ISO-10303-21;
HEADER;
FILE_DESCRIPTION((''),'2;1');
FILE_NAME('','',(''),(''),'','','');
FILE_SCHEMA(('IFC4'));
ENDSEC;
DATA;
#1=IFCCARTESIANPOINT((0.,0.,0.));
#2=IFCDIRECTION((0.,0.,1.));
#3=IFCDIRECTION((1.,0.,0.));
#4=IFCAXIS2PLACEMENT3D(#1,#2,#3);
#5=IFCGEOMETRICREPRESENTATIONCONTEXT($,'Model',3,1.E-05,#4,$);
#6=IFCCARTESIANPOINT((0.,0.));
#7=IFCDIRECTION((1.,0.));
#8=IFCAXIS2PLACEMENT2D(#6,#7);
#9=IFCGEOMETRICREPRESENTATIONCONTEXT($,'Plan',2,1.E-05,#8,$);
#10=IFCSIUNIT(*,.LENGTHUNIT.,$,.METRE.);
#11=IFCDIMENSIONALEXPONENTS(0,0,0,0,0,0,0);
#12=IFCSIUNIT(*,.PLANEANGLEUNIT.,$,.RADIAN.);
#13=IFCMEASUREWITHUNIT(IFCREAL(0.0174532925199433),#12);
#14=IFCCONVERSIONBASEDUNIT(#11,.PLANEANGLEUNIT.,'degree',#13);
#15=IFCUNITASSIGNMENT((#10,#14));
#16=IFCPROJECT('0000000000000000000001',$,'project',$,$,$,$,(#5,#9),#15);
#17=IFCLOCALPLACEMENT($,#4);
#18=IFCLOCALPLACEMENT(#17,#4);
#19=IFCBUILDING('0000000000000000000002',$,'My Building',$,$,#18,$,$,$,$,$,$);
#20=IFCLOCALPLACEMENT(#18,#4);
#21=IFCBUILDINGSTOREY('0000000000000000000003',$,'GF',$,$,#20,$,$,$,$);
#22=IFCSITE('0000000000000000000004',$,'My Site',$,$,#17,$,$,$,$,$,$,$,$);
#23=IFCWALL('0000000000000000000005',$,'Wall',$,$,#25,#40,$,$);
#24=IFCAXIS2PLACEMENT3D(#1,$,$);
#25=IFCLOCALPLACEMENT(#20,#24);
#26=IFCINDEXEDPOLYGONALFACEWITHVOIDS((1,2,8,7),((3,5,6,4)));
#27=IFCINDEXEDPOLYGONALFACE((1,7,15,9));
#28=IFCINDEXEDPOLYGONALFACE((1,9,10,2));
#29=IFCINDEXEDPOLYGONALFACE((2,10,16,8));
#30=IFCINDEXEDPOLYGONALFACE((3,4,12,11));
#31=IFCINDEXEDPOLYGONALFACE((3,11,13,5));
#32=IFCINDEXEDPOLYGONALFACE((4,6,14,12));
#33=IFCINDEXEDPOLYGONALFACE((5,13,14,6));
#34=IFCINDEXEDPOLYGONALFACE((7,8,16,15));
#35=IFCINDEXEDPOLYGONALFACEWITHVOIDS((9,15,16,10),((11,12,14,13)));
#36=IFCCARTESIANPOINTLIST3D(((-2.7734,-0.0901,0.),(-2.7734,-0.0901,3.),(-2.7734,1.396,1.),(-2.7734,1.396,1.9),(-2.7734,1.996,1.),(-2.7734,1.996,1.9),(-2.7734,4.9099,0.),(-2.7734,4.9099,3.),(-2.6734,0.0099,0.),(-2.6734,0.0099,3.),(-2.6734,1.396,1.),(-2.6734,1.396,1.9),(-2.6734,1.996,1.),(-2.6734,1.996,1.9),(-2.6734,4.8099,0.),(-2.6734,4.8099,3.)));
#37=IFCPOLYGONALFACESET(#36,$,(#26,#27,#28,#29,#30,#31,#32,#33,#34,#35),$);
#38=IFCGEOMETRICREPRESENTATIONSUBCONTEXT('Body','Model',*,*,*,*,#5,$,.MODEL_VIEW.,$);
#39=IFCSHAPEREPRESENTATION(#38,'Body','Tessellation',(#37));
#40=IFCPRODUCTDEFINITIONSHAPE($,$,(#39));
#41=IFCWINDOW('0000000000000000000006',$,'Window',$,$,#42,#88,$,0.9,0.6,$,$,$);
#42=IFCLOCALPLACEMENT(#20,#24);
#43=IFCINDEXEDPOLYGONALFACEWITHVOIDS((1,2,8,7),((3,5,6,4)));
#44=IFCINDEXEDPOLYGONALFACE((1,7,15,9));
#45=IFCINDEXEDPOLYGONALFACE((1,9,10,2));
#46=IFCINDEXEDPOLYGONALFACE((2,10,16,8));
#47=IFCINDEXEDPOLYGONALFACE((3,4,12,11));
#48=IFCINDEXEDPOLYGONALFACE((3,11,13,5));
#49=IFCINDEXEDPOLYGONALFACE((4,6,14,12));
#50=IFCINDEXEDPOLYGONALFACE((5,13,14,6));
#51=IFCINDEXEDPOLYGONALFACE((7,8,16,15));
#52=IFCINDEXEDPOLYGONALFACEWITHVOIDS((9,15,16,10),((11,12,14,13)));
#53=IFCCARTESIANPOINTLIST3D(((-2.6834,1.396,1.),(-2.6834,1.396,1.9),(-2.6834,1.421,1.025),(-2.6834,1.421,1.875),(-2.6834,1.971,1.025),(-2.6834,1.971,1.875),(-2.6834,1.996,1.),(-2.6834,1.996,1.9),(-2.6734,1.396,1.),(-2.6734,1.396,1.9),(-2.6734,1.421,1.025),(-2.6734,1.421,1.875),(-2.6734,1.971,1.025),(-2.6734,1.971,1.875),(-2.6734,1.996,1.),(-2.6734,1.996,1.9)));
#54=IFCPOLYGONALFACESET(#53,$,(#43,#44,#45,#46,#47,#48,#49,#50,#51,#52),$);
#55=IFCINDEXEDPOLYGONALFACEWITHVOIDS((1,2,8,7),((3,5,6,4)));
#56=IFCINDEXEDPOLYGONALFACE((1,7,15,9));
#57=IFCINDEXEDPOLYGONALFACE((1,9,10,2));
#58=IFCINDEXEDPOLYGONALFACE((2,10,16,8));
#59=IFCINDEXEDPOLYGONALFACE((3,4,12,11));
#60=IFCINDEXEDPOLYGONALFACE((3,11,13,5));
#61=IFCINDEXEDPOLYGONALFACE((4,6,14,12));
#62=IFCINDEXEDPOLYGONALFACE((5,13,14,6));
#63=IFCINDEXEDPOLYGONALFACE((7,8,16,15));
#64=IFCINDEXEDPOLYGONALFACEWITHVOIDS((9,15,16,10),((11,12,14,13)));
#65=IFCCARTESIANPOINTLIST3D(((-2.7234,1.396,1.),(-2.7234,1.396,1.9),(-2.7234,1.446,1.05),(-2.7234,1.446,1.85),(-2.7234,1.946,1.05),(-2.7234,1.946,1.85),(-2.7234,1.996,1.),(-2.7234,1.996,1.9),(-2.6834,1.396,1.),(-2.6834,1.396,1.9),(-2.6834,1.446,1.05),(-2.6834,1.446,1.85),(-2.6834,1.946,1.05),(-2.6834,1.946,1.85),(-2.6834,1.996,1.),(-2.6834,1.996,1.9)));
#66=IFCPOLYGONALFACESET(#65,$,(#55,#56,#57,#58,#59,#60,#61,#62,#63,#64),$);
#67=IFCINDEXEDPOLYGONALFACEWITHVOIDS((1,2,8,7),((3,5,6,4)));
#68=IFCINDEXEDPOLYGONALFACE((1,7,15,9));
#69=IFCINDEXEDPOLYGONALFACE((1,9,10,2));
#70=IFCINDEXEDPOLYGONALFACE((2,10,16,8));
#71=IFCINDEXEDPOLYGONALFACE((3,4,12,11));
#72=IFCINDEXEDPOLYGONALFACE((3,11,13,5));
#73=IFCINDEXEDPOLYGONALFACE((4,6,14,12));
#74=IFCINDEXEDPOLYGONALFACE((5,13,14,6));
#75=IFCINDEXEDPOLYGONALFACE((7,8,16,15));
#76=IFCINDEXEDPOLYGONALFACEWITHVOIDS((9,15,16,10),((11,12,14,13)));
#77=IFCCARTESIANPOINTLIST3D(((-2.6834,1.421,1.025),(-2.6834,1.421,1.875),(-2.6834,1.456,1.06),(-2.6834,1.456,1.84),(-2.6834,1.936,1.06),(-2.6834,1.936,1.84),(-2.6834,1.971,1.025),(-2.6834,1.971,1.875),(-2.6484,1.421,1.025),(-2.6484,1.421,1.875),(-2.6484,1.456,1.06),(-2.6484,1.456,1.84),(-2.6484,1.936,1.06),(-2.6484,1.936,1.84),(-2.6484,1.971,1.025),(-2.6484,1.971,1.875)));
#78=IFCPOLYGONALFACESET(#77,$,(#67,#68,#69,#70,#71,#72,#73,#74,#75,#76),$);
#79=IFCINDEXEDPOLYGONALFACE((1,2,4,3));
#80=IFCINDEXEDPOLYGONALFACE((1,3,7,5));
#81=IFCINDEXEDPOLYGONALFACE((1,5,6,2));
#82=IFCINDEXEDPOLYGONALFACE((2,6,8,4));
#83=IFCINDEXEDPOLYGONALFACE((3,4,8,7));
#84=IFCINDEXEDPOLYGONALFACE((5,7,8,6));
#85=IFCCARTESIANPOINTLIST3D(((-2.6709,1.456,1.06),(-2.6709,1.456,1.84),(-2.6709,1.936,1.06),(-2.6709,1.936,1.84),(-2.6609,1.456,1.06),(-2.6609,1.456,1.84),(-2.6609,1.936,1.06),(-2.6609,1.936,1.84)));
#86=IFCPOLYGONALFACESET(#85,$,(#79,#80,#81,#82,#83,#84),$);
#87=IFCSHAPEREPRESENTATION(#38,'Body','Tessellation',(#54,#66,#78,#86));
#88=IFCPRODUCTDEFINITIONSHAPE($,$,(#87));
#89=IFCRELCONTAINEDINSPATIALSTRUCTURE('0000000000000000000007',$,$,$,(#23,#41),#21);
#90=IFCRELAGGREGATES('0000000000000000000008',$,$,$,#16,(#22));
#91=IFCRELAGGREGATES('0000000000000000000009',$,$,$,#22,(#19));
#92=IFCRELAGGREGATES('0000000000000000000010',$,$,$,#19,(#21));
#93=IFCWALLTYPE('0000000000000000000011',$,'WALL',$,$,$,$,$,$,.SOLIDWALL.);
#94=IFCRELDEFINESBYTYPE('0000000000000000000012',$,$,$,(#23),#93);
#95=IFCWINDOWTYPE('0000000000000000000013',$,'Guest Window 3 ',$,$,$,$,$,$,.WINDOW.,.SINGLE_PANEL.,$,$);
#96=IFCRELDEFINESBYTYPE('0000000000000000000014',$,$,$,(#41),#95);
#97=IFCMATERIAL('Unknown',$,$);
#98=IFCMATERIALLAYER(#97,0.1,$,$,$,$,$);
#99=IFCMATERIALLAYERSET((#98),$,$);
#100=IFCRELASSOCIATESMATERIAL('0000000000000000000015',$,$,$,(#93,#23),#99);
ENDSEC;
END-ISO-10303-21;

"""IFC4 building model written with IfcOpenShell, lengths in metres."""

from ifc_helpers import new_model, entity, si_unit, converted_unit, frame, origin_with_axes, origin_2d_with_axis, place, context, subcontext, project, spatial, line, indexed_curve, outline, extrude, shape, source, transform, mapped, material, layer, layer_set, layer_usage, type_object, type_shapes, element, fill, save


model = new_model("IFC4")

# Units and contexts
model_context = context("Model", 3, precision=1e-05, world=origin_with_axes())
plan_context = context("Plan", 2, precision=1e-05, world=origin_2d_with_axis())
body_context_1 = subcontext(model_context, "Body", "Model", "MODEL_VIEW")
body_context_2 = subcontext(plan_context, "Body", "Plan", "PLAN_VIEW")
ifc_project = project(units=[si_unit("LENGTHUNIT", "METRE"), converted_unit("PLANEANGLEUNIT", "degree", entity("IfcReal", 0.0174532925199433), si_unit("PLANEANGLEUNIT", "RADIAN"), dimensions=[0, 0, 0, 0, 0, 0, 0])], contexts=[model_context, plan_context])

# Site, building, storey
site_placement = place(None, origin_with_axes())
site = spatial("IfcSite", under=ifc_project, at=site_placement, Name="My Site")
building_placement = place(site_placement, origin_with_axes())
building = spatial("IfcBuilding", under=site, at=building_placement, Name="My Building")
storey_placement = place(building_placement, origin_with_axes())
storey = spatial("IfcBuildingStorey", under=building, at=storey_placement, Name="GF")

# Shared definitions
ifc_material_1 = material(Name="Unknown")

# Shared definitions
ifc_layer_1 = layer(ifc_material_1, 0.1)
ifc_layer_set_1 = layer_set([ifc_layer_1])
wall_type = type_object("IfcWallType", Name="WALL", PredefinedType="SOLIDWALL", material=ifc_layer_set_1)

# Wall, opening, window
ifc_layer_usage_1 = layer_usage(ifc_layer_set_1, "AXIS2", "POSITIVE", 0.0)
wall_1_placement = place(storey_placement, frame((-2.7734, 4.9099, 0.0), z_axis=(0.0, 0.0, 1.0), x_axis=(0.0, -1.0, 0.0)))
wall_1 = element("IfcWall", 1, at=wall_1_placement, inside=storey, type_object=wall_type, material=ifc_layer_usage_1, Name="Wall", context=body_context_1, shape_type="SweptSolid", body=[
    extrude(outline(indexed_curve([(0.0, 0.0), (0.1, 0.1), (4.9, 0.1), (5.0, 0.0)], segments=[line(1, 2, 3, 4, 1)])), origin_with_axes(), (0.0, 0.0, 1.0), 3.0),
])
shared_shape_1 = source(origin_with_axes(), body_context_1, "Body", "SweptSolid", [
    extrude(outline(indexed_curve([(0.0, 0.0), (0.6, 0.0), (0.6, 0.9), (0.0, 0.9)], segments=[line(1, 2, 3, 4, 1)])), frame((0.0, -0.6, 0.0), z_axis=(0.0, -1.0, 0.0), x_axis=(1.0, 0.0, 0.0)), (0.0, 0.0, -1.0), 1.2),
])
opening_1_placement = place(wall_1_placement, frame((2.9139, 0.0, 1.0), z_axis=(0.0, 0.0, 1.0), x_axis=(1.0, 0.0, 0.0)))
opening_1 = element("IfcOpeningElement", 2, at=opening_1_placement, cuts=wall_1, PredefinedType="OPENING", context=body_context_1, shape_type="MappedRepresentation", body=[
    mapped(shared_shape_1, transform((0.0, 0.0, 0.0), x_axis=(1.0, 0.0, 0.0), y_axis=(0.0, 1.0, 0.0), z_axis=(0.0, 0.0, 1.0), scale=1.0)),
])
window_type_1 = type_object("IfcWindowType", Name="Guest Window 3 ", PartitioningType="SINGLE_PANEL", PredefinedType="WINDOW")
shared_shape_2 = source(origin_with_axes(), body_context_1, "Body", "SweptSolid", [
    extrude(outline(indexed_curve([(0.0, 0.0), (0.6, 0.0), (0.6, 0.9), (0.0, 0.9)], segments=[line(1, 2, 3, 4, 1)]), holes=[indexed_curve([(0.025, 0.025), (0.575, 0.025), (0.575, 0.875), (0.025, 0.875)], segments=[line(1, 2, 3, 4, 1)])]), frame((0.0, 0.09, 0.0), z_axis=(0.0, -1.0, 0.0), x_axis=(1.0, 0.0, 0.0)), (0.0, 0.0, -1.0), 0.01),
    extrude(outline(indexed_curve([(0.0, 0.0), (0.6, 0.0), (0.6, 0.9), (0.0, 0.9)], segments=[line(1, 2, 3, 4, 1)]), holes=[indexed_curve([(0.05, 0.05), (0.55, 0.05), (0.55, 0.85), (0.05, 0.85)], segments=[line(1, 2, 3, 4, 1)])]), frame((0.0, 0.05, 0.0), z_axis=(0.0, -1.0, 0.0), x_axis=(1.0, 0.0, 0.0)), (0.0, 0.0, -1.0), 0.04),
    extrude(outline(indexed_curve([(0.0, 0.0), (0.55, 0.0), (0.55, 0.85), (0.0, 0.85)], segments=[line(1, 2, 3, 4, 1)]), holes=[indexed_curve([(0.035, 0.035), (0.515, 0.035), (0.515, 0.815), (0.035, 0.815)], segments=[line(1, 2, 3, 4, 1)])]), frame((0.025, 0.09, 0.025), z_axis=(0.0, -1.0, 0.0), x_axis=(1.0, 0.0, 0.0)), (0.0, 0.0, -1.0), 0.035),
    extrude(outline(indexed_curve([(0.035, 0.035), (0.515, 0.035), (0.515, 0.815), (0.035, 0.815)], segments=[line(1, 2, 3, 4, 1)])), frame((0.025, 0.1025, 0.025), z_axis=(0.0, -1.0, 0.0), x_axis=(1.0, 0.0, 0.0)), (0.0, 0.0, -1.0), 0.01),
])
shared_shape_3 = source(origin_with_axes(), body_context_2, "Body", "Curve2D", [
    entity("IfcIndexedPolyCurve", entity("IfcCartesianPointList2D", [[0.05, 0.05], [0.55, 0.05]])),
    entity("IfcIndexedPolyCurve", entity("IfcCartesianPointList2D", [[0.0, 0.1], [0.025, 0.1], [0.025, 0.09], [0.05, 0.09], [0.05, 0.05], [0.0, 0.05]]), [entity("IfcLineIndex", [1, 2, 3, 4, 5, 6, 1])]),
    entity("IfcIndexedPolyCurve", entity("IfcCartesianPointList2D", [[0.6, 0.1], [0.575, 0.1], [0.575, 0.09], [0.55, 0.09], [0.55, 0.05], [0.6, 0.05]]), [entity("IfcLineIndex", [1, 2, 3, 4, 5, 6, 1])]),
    entity("IfcIndexedPolyCurve", entity("IfcCartesianPointList2D", [[0.025, 0.09], [0.06, 0.09], [0.06, 0.125], [0.025, 0.125]]), [entity("IfcLineIndex", [1, 2, 3, 4, 1])]),
    entity("IfcIndexedPolyCurve", entity("IfcCartesianPointList2D", [[0.575, 0.09], [0.54, 0.09], [0.54, 0.125], [0.575, 0.125]]), [entity("IfcLineIndex", [1, 2, 3, 4, 1])]),
    entity("IfcIndexedPolyCurve", entity("IfcCartesianPointList2D", [[0.06, 0.09], [0.54, 0.09]])),
    entity("IfcIndexedPolyCurve", entity("IfcCartesianPointList2D", [[0.06, 0.125], [0.54, 0.125]])),
    entity("IfcIndexedPolyCurve", entity("IfcCartesianPointList2D", [[0.06, 0.1075], [0.54, 0.1075]])),
])
type_shapes(window_type_1, [shared_shape_2, shared_shape_3])
window_1_placement = place(opening_1_placement, origin_with_axes())
window_1 = element("IfcWindow", 3, at=window_1_placement, inside=storey, type_object=window_type_1, Name="Window", OverallHeight=0.9, OverallWidth=0.6, shapes=[
    shape(body_context_1, "Body", "MappedRepresentation", [mapped(shared_shape_2, transform((0.0, 0.0, 0.0), x_axis=(1.0, 0.0, 0.0), y_axis=(0.0, 1.0, 0.0), z_axis=(0.0, 0.0, 1.0), scale=1.0))]),
    shape(body_context_2, "Body", "MappedRepresentation", [mapped(shared_shape_3, transform((0.0, 0.0, 0.0), x_axis=(1.0, 0.0, 0.0), y_axis=(0.0, 1.0, 0.0), z_axis=(0.0, 0.0, 1.0), scale=1.0))]),
])
fill(opening_1, window_1)

save(model, "model.ifc")
